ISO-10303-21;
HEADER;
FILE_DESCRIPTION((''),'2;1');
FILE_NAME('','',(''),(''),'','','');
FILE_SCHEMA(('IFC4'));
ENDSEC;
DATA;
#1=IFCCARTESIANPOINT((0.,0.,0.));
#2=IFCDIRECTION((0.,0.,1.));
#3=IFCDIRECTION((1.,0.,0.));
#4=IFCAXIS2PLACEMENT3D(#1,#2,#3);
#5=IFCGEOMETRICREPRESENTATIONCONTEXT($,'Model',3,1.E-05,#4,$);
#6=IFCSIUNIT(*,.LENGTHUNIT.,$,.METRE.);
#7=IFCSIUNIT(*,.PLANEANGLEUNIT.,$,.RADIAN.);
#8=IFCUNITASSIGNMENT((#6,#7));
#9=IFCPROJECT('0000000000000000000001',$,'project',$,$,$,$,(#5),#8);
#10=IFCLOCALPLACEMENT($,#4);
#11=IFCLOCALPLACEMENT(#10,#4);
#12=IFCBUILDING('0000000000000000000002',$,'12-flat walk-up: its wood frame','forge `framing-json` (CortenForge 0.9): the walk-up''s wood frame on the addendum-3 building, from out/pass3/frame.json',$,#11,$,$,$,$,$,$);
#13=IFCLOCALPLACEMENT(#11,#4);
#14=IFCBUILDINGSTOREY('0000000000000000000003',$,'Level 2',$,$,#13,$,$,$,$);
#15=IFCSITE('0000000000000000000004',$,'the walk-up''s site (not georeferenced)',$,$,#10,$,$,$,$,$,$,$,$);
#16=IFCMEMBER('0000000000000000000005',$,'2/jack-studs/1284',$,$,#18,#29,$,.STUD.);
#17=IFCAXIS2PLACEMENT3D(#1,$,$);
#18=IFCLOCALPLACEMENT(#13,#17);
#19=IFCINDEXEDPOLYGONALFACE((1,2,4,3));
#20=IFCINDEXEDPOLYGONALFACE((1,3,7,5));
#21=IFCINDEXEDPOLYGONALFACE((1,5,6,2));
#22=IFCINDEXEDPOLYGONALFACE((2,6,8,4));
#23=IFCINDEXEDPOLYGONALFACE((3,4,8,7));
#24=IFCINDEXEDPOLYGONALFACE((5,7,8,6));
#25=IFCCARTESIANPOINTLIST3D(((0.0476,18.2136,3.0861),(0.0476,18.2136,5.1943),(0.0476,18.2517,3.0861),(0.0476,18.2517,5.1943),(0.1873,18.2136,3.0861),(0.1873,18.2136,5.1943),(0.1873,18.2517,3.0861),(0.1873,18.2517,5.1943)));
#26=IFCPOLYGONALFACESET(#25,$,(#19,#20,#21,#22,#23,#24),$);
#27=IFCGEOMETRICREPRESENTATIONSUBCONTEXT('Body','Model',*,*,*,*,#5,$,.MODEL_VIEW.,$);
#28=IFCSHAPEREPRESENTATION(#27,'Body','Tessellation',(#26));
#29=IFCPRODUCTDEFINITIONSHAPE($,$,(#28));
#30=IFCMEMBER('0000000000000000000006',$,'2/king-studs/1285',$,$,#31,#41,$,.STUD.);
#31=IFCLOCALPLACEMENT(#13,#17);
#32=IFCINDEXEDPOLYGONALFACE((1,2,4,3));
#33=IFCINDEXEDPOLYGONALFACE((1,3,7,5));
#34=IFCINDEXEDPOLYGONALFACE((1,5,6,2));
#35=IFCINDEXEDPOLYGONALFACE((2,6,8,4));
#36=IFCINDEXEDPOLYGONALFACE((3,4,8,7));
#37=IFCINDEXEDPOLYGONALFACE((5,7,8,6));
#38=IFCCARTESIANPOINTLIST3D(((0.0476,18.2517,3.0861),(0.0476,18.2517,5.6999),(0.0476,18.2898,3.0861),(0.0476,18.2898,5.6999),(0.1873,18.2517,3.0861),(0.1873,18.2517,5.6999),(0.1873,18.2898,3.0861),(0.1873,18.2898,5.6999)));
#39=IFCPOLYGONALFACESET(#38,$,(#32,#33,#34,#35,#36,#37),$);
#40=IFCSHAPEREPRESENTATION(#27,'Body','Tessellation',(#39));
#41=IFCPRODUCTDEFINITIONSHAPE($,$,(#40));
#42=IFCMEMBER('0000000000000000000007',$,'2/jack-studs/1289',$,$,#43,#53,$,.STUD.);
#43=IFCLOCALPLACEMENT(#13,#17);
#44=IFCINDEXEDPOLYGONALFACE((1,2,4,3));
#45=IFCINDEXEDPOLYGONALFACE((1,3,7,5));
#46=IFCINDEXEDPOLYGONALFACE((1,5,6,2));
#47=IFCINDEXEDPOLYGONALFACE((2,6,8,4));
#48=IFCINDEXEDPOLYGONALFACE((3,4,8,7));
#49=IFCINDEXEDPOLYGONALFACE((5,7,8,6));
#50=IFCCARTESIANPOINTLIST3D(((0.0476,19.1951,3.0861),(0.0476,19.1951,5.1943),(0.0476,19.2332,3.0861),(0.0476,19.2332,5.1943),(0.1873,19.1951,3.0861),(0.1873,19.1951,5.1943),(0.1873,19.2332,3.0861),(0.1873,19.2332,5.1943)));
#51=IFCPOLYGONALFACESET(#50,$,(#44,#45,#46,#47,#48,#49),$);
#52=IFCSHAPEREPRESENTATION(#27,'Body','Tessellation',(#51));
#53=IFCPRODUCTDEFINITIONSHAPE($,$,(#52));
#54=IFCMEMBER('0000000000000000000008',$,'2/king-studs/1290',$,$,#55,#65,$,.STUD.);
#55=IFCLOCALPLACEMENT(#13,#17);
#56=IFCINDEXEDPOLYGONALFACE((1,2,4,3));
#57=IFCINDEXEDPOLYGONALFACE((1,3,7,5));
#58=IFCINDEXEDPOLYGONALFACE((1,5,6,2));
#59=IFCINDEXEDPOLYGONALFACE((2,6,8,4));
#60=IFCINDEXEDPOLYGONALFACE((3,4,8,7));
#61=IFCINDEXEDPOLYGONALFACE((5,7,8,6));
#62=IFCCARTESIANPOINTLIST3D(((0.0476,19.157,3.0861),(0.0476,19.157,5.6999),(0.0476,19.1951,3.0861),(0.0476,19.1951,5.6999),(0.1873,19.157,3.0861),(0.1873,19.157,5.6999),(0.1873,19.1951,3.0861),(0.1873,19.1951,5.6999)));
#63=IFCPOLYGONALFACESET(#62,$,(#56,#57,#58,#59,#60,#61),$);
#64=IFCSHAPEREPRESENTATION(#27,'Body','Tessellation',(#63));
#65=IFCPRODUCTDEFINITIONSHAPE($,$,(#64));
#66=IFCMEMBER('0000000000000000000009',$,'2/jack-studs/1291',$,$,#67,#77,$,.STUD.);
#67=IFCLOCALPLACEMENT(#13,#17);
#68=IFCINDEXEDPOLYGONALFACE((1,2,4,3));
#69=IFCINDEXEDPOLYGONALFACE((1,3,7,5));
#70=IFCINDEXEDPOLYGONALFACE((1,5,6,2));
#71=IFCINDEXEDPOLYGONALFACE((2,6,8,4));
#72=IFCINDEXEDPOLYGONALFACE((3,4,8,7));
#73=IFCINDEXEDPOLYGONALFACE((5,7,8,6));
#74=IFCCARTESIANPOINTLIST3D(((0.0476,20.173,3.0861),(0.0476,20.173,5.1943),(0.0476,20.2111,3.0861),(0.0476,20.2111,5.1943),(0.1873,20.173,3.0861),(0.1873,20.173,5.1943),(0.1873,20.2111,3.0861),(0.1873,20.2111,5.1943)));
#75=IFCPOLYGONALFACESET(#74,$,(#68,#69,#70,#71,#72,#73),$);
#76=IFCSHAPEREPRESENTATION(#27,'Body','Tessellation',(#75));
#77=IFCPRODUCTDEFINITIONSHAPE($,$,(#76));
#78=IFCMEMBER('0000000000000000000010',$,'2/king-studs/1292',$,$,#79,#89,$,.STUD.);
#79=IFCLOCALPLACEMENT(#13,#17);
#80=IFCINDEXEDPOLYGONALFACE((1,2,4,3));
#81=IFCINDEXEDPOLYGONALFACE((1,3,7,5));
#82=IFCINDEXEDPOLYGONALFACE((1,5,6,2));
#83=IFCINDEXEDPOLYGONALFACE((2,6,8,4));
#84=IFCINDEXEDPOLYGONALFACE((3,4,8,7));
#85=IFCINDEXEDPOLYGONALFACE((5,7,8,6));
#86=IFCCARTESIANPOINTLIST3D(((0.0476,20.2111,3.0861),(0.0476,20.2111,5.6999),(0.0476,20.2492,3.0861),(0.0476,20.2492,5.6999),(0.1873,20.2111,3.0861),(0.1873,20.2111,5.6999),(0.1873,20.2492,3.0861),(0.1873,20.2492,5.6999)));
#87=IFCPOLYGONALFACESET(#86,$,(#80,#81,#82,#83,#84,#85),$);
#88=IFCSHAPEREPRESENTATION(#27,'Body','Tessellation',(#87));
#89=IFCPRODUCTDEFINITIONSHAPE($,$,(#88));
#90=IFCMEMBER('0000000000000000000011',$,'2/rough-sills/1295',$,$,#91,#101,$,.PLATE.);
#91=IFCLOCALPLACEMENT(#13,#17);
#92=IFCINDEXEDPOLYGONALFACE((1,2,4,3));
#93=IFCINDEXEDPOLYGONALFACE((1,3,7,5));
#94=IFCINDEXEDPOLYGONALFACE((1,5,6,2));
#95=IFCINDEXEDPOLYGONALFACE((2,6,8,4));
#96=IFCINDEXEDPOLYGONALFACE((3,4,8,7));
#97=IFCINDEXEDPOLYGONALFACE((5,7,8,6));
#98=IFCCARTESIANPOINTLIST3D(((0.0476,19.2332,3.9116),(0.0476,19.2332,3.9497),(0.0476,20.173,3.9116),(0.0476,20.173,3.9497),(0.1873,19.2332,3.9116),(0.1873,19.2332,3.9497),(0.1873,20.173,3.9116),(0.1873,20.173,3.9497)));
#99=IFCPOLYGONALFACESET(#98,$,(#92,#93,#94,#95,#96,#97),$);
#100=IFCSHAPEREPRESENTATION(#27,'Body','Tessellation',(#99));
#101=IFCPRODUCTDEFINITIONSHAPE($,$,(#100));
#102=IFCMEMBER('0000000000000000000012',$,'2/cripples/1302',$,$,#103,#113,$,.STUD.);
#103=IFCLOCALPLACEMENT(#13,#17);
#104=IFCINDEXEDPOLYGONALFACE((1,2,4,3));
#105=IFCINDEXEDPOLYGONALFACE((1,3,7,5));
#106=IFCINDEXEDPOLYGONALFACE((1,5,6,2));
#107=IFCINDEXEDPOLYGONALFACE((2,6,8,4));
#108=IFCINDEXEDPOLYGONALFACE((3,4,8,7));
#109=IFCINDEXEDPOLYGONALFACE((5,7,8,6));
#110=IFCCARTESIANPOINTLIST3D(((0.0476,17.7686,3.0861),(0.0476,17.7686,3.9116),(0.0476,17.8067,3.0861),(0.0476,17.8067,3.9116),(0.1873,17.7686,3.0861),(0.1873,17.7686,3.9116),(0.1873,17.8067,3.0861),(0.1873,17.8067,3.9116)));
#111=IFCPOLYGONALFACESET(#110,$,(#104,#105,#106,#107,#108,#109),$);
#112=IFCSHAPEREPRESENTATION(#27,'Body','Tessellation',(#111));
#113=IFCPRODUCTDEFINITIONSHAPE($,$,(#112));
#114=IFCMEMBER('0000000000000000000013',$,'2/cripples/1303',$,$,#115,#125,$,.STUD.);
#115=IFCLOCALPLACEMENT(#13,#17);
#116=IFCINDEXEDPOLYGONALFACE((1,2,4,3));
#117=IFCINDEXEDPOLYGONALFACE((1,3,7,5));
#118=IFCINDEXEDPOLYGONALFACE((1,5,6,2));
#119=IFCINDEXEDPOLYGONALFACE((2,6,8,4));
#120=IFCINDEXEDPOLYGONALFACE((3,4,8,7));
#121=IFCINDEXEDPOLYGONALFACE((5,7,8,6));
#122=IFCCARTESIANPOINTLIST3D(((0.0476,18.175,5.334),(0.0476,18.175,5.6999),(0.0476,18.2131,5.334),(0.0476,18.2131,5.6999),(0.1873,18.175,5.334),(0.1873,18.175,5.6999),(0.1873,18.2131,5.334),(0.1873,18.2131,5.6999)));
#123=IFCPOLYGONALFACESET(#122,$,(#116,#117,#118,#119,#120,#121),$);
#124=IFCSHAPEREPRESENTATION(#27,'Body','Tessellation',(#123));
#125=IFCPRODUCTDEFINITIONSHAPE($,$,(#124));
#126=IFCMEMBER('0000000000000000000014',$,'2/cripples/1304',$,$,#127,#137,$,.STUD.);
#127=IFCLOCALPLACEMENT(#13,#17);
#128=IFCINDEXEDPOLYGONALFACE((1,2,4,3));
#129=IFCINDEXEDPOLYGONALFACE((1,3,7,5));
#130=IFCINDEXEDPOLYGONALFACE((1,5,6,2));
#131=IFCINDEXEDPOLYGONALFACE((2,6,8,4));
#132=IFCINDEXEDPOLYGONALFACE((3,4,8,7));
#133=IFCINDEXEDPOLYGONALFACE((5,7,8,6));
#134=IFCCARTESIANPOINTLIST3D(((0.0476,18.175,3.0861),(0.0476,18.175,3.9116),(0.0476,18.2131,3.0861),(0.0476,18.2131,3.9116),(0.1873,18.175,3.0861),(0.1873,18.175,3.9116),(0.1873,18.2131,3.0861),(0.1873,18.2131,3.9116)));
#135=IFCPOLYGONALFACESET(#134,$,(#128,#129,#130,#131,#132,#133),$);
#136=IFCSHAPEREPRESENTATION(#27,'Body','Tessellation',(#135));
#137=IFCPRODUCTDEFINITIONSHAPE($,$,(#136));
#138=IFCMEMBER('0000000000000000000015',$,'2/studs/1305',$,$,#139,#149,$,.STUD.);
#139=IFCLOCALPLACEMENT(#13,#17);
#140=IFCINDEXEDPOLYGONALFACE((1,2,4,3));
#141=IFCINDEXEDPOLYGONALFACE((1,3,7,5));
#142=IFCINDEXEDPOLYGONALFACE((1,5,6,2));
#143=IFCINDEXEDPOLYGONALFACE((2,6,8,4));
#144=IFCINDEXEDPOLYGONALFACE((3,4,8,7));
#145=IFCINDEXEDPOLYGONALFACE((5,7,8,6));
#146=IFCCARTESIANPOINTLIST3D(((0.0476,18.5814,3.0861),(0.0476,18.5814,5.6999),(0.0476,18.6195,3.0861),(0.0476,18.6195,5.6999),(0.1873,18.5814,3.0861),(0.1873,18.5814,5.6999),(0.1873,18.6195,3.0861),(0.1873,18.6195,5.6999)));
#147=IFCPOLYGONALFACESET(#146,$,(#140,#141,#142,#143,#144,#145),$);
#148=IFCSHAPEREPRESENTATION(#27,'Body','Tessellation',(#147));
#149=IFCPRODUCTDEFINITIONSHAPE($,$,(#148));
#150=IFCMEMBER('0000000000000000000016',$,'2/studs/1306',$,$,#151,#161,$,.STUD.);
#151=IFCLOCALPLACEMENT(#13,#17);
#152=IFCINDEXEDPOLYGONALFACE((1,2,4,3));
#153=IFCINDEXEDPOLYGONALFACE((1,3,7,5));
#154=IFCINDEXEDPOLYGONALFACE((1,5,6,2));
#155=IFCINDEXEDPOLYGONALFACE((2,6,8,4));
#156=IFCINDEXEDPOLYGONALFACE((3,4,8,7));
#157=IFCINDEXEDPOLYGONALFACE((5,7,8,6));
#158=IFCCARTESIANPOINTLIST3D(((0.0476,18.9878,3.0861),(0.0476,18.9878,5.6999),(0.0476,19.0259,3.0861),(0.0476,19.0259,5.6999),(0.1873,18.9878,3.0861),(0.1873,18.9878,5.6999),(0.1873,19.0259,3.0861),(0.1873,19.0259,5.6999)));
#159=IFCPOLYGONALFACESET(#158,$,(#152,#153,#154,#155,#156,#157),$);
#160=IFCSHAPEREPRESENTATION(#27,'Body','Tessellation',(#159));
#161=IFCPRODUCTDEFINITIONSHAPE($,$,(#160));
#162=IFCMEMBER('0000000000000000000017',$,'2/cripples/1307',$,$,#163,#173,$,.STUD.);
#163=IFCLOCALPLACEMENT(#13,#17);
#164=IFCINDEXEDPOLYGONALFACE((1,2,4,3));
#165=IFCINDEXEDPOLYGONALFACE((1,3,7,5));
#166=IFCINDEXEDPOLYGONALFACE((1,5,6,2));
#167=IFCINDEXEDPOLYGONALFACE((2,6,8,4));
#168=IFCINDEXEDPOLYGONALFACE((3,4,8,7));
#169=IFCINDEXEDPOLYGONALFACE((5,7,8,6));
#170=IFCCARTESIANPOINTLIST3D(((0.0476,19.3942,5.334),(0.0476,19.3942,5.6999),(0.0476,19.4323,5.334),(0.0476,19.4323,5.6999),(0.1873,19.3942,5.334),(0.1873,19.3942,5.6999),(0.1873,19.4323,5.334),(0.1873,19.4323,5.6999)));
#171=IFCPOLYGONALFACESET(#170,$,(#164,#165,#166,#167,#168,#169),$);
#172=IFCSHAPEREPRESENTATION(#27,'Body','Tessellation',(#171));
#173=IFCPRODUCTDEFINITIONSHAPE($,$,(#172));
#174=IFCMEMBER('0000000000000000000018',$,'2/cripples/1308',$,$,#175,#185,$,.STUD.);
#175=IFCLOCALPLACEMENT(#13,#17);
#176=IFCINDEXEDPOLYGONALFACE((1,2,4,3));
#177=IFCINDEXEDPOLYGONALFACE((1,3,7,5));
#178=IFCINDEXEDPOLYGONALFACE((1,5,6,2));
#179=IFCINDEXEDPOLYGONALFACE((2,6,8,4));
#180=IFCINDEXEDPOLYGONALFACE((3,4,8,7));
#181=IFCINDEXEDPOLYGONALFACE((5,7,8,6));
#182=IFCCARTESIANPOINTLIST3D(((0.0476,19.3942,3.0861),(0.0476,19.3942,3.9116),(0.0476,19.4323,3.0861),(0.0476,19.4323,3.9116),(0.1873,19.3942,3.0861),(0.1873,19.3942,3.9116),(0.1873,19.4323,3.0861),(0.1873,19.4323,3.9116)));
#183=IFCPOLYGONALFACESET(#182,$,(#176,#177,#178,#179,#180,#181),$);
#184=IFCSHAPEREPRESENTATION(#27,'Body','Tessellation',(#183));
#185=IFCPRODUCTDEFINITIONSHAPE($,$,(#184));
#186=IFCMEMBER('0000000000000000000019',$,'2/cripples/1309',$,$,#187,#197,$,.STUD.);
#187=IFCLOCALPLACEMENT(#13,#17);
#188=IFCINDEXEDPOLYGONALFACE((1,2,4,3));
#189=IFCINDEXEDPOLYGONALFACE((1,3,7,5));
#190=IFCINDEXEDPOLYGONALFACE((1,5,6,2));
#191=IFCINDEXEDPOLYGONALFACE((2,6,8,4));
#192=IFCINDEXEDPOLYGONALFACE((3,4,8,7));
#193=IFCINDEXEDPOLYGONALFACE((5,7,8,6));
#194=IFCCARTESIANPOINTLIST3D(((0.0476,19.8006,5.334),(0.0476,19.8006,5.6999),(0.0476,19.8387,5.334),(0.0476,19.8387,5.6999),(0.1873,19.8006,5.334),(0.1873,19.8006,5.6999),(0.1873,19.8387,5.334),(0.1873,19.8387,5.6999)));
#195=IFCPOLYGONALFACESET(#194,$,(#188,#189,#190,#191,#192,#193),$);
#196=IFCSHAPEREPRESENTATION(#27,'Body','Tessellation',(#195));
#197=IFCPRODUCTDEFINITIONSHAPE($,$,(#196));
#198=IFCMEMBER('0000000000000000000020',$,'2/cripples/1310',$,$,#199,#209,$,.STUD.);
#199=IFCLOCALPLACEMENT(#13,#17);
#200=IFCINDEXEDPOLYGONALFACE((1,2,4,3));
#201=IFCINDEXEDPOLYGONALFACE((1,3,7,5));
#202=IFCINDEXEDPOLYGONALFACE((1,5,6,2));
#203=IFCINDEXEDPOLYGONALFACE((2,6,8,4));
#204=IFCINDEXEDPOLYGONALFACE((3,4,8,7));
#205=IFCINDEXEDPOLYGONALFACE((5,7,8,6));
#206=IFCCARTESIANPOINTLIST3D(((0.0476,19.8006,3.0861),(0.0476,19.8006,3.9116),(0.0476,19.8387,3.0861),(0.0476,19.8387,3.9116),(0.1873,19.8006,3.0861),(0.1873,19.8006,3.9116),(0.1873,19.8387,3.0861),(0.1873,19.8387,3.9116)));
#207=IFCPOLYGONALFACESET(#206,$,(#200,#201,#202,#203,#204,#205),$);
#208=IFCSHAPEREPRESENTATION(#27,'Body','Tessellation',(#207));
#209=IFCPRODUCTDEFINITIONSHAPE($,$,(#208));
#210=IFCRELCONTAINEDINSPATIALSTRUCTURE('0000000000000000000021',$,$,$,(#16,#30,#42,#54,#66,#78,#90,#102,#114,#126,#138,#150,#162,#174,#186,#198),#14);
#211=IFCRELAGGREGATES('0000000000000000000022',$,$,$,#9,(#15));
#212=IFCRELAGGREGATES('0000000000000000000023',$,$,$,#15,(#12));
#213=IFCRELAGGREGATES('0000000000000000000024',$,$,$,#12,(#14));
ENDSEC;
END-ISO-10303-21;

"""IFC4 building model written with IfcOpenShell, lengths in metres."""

from ifc_helpers import new_model, si_unit, frame, frame_2d, origin, origin_with_axes, place, context, subcontext, project, spatial, rectangle, extrude, element, save


model = new_model("IFC4")

# Units and contexts
model_context = context("Model", 3, precision=1e-05, world=origin_with_axes())
body_context = subcontext(model_context, "Body", "Model", "MODEL_VIEW")
ifc_project = project(units=[si_unit("LENGTHUNIT", "METRE"), si_unit("PLANEANGLEUNIT", "RADIAN")], contexts=[model_context])

# Site, building, storey
site_placement = place(None, origin_with_axes())
site = spatial("IfcSite", under=ifc_project, at=site_placement, Name="the walk-up's site (not georeferenced)")
building_placement = place(site_placement, origin_with_axes())
building = spatial("IfcBuilding", under=site, at=building_placement, Name="12-flat walk-up: its wood frame", Description="forge `framing-json` (CortenForge 0.9): the walk-up's wood frame on the addendum-3 building, from out/pass3/frame.json")
storey_placement = place(building_placement, origin_with_axes())
storey = spatial("IfcBuildingStorey", under=building, at=storey_placement, Name="Level 2")

# Members
member_1_placement = place(storey_placement, frame((0.0476, 18.2136, 3.0861), z_axis=(0.0, 0.0, 1.0), x_axis=(1.0, 0.0, 0.0)))
element("IfcMember", 1, at=member_1_placement, inside=storey, Name="2/jack-studs/1284", PredefinedType="STUD", context=body_context, shape_type="SweptSolid", body=[
    extrude(rectangle(XDim=0.1397, YDim=0.0381, at=frame_2d((0.0698, 0.0191))), origin(), (0.0, 0.0, 1.0), 2.1082),
])
member_2_placement = place(storey_placement, frame((0.0476, 18.2517, 3.0861), z_axis=(0.0, 0.0, 1.0), x_axis=(1.0, 0.0, 0.0)))
element("IfcMember", 2, at=member_2_placement, inside=storey, Name="2/king-studs/1285", PredefinedType="STUD", context=body_context, shape_type="SweptSolid", body=[
    extrude(rectangle(XDim=0.1397, YDim=0.0381, at=frame_2d((0.0698, 0.0191))), origin(), (0.0, 0.0, 1.0), 2.6138),
])
member_3_placement = place(storey_placement, frame((0.0476, 19.1951, 3.0861), z_axis=(0.0, 0.0, 1.0), x_axis=(1.0, 0.0, 0.0)))
element("IfcMember", 3, at=member_3_placement, inside=storey, Name="2/jack-studs/1289", PredefinedType="STUD", context=body_context, shape_type="SweptSolid", body=[
    extrude(rectangle(XDim=0.1397, YDim=0.0381, at=frame_2d((0.0698, 0.0191))), origin(), (0.0, 0.0, 1.0), 2.1082),
])
member_4_placement = place(storey_placement, frame((0.0476, 19.157, 3.0861), z_axis=(0.0, 0.0, 1.0), x_axis=(1.0, 0.0, 0.0)))
element("IfcMember", 4, at=member_4_placement, inside=storey, Name="2/king-studs/1290", PredefinedType="STUD", context=body_context, shape_type="SweptSolid", body=[
    extrude(rectangle(XDim=0.1397, YDim=0.0381, at=frame_2d((0.0698, 0.0191))), origin(), (0.0, 0.0, 1.0), 2.6138),
])
member_5_placement = place(storey_placement, frame((0.0476, 20.173, 3.0861), z_axis=(0.0, 0.0, 1.0), x_axis=(1.0, 0.0, 0.0)))
element("IfcMember", 5, at=member_5_placement, inside=storey, Name="2/jack-studs/1291", PredefinedType="STUD", context=body_context, shape_type="SweptSolid", body=[
    extrude(rectangle(XDim=0.1397, YDim=0.0381, at=frame_2d((0.0698, 0.0191))), origin(), (0.0, 0.0, 1.0), 2.1082),
])
member_6_placement = place(storey_placement, frame((0.0476, 20.2111, 3.0861), z_axis=(0.0, 0.0, 1.0), x_axis=(1.0, 0.0, 0.0)))
element("IfcMember", 6, at=member_6_placement, inside=storey, Name="2/king-studs/1292", PredefinedType="STUD", context=body_context, shape_type="SweptSolid", body=[
    extrude(rectangle(XDim=0.1397, YDim=0.0381, at=frame_2d((0.0698, 0.0191))), origin(), (0.0, 0.0, 1.0), 2.6138),
])
member_7_placement = place(storey_placement, frame((0.0476, 19.2332, 3.9116), z_axis=(0.0, 0.0, 1.0), x_axis=(1.0, 0.0, 0.0)))
element("IfcMember", 7, at=member_7_placement, inside=storey, Name="2/rough-sills/1295", PredefinedType="PLATE", context=body_context, shape_type="SweptSolid", body=[
    extrude(rectangle(XDim=0.1397, YDim=0.9398, at=frame_2d((0.0698, 0.4699))), origin(), (0.0, 0.0, 1.0), 0.0381),
])
member_8_placement = place(storey_placement, frame((0.0476, 17.7686, 3.0861), z_axis=(0.0, 0.0, 1.0), x_axis=(1.0, 0.0, 0.0)))
element("IfcMember", 8, at=member_8_placement, inside=storey, Name="2/cripples/1302", PredefinedType="STUD", context=body_context, shape_type="SweptSolid", body=[
    extrude(rectangle(XDim=0.1397, YDim=0.0381, at=frame_2d((0.0698, 0.0191))), origin(), (0.0, 0.0, 1.0), 0.8255),
])
member_9_placement = place(storey_placement, frame((0.0476, 18.175, 5.334), z_axis=(0.0, 0.0, 1.0), x_axis=(1.0, 0.0, 0.0)))
element("IfcMember", 9, at=member_9_placement, inside=storey, Name="2/cripples/1303", PredefinedType="STUD", context=body_context, shape_type="SweptSolid", body=[
    extrude(rectangle(XDim=0.1397, YDim=0.0381, at=frame_2d((0.0698, 0.0191))), origin(), (0.0, 0.0, 1.0), 0.3659),
])
member_10_placement = place(storey_placement, frame((0.0476, 18.175, 3.0861), z_axis=(0.0, 0.0, 1.0), x_axis=(1.0, 0.0, 0.0)))
element("IfcMember", 10, at=member_10_placement, inside=storey, Name="2/cripples/1304", PredefinedType="STUD", context=body_context, shape_type="SweptSolid", body=[
    extrude(rectangle(XDim=0.1397, YDim=0.0381, at=frame_2d((0.0698, 0.0191))), origin(), (0.0, 0.0, 1.0), 0.8255),
])
for number, where, z_axis, x_axis, name in (
    (11, (0.0476, 18.5814, 3.0861), (0.0, 0.0, 1.0), (1.0, 0.0, 0.0), "2/studs/1305"),
    (12, (0.0476, 18.9878, 3.0861), (0.0, 0.0, 1.0), (1.0, 0.0, 0.0), "2/studs/1306"),
):
    element("IfcMember", number, at=place(storey_placement, frame(where, z_axis=z_axis, x_axis=x_axis)), inside=storey, Name=name, PredefinedType="STUD", context=body_context, shape_type="SweptSolid", body=[
        extrude(rectangle(XDim=0.1397, YDim=0.0381, at=frame_2d((0.0698, 0.0191))), origin(), (0.0, 0.0, 1.0), 2.6138),
    ])
member_11_placement = place(storey_placement, frame((0.0476, 19.3942, 5.334), z_axis=(0.0, 0.0, 1.0), x_axis=(1.0, 0.0, 0.0)))
element("IfcMember", 13, at=member_11_placement, inside=storey, Name="2/cripples/1307", PredefinedType="STUD", context=body_context, shape_type="SweptSolid", body=[
    extrude(rectangle(XDim=0.1397, YDim=0.0381, at=frame_2d((0.0698, 0.0191))), origin(), (0.0, 0.0, 1.0), 0.3659),
])
member_12_placement = place(storey_placement, frame((0.0476, 19.3942, 3.0861), z_axis=(0.0, 0.0, 1.0), x_axis=(1.0, 0.0, 0.0)))
element("IfcMember", 14, at=member_12_placement, inside=storey, Name="2/cripples/1308", PredefinedType="STUD", context=body_context, shape_type="SweptSolid", body=[
    extrude(rectangle(XDim=0.1397, YDim=0.0381, at=frame_2d((0.0698, 0.0191))), origin(), (0.0, 0.0, 1.0), 0.8255),
])
member_13_placement = place(storey_placement, frame((0.0476, 19.8006, 5.334), z_axis=(0.0, 0.0, 1.0), x_axis=(1.0, 0.0, 0.0)))
element("IfcMember", 15, at=member_13_placement, inside=storey, Name="2/cripples/1309", PredefinedType="STUD", context=body_context, shape_type="SweptSolid", body=[
    extrude(rectangle(XDim=0.1397, YDim=0.0381, at=frame_2d((0.0698, 0.0191))), origin(), (0.0, 0.0, 1.0), 0.3659),
])
member_14_placement = place(storey_placement, frame((0.0476, 19.8006, 3.0861), z_axis=(0.0, 0.0, 1.0), x_axis=(1.0, 0.0, 0.0)))
element("IfcMember", 16, at=member_14_placement, inside=storey, Name="2/cripples/1310", PredefinedType="STUD", context=body_context, shape_type="SweptSolid", body=[
    extrude(rectangle(XDim=0.1397, YDim=0.0381, at=frame_2d((0.0698, 0.0191))), origin(), (0.0, 0.0, 1.0), 0.8255),
])

save(model, "model.ifc")
